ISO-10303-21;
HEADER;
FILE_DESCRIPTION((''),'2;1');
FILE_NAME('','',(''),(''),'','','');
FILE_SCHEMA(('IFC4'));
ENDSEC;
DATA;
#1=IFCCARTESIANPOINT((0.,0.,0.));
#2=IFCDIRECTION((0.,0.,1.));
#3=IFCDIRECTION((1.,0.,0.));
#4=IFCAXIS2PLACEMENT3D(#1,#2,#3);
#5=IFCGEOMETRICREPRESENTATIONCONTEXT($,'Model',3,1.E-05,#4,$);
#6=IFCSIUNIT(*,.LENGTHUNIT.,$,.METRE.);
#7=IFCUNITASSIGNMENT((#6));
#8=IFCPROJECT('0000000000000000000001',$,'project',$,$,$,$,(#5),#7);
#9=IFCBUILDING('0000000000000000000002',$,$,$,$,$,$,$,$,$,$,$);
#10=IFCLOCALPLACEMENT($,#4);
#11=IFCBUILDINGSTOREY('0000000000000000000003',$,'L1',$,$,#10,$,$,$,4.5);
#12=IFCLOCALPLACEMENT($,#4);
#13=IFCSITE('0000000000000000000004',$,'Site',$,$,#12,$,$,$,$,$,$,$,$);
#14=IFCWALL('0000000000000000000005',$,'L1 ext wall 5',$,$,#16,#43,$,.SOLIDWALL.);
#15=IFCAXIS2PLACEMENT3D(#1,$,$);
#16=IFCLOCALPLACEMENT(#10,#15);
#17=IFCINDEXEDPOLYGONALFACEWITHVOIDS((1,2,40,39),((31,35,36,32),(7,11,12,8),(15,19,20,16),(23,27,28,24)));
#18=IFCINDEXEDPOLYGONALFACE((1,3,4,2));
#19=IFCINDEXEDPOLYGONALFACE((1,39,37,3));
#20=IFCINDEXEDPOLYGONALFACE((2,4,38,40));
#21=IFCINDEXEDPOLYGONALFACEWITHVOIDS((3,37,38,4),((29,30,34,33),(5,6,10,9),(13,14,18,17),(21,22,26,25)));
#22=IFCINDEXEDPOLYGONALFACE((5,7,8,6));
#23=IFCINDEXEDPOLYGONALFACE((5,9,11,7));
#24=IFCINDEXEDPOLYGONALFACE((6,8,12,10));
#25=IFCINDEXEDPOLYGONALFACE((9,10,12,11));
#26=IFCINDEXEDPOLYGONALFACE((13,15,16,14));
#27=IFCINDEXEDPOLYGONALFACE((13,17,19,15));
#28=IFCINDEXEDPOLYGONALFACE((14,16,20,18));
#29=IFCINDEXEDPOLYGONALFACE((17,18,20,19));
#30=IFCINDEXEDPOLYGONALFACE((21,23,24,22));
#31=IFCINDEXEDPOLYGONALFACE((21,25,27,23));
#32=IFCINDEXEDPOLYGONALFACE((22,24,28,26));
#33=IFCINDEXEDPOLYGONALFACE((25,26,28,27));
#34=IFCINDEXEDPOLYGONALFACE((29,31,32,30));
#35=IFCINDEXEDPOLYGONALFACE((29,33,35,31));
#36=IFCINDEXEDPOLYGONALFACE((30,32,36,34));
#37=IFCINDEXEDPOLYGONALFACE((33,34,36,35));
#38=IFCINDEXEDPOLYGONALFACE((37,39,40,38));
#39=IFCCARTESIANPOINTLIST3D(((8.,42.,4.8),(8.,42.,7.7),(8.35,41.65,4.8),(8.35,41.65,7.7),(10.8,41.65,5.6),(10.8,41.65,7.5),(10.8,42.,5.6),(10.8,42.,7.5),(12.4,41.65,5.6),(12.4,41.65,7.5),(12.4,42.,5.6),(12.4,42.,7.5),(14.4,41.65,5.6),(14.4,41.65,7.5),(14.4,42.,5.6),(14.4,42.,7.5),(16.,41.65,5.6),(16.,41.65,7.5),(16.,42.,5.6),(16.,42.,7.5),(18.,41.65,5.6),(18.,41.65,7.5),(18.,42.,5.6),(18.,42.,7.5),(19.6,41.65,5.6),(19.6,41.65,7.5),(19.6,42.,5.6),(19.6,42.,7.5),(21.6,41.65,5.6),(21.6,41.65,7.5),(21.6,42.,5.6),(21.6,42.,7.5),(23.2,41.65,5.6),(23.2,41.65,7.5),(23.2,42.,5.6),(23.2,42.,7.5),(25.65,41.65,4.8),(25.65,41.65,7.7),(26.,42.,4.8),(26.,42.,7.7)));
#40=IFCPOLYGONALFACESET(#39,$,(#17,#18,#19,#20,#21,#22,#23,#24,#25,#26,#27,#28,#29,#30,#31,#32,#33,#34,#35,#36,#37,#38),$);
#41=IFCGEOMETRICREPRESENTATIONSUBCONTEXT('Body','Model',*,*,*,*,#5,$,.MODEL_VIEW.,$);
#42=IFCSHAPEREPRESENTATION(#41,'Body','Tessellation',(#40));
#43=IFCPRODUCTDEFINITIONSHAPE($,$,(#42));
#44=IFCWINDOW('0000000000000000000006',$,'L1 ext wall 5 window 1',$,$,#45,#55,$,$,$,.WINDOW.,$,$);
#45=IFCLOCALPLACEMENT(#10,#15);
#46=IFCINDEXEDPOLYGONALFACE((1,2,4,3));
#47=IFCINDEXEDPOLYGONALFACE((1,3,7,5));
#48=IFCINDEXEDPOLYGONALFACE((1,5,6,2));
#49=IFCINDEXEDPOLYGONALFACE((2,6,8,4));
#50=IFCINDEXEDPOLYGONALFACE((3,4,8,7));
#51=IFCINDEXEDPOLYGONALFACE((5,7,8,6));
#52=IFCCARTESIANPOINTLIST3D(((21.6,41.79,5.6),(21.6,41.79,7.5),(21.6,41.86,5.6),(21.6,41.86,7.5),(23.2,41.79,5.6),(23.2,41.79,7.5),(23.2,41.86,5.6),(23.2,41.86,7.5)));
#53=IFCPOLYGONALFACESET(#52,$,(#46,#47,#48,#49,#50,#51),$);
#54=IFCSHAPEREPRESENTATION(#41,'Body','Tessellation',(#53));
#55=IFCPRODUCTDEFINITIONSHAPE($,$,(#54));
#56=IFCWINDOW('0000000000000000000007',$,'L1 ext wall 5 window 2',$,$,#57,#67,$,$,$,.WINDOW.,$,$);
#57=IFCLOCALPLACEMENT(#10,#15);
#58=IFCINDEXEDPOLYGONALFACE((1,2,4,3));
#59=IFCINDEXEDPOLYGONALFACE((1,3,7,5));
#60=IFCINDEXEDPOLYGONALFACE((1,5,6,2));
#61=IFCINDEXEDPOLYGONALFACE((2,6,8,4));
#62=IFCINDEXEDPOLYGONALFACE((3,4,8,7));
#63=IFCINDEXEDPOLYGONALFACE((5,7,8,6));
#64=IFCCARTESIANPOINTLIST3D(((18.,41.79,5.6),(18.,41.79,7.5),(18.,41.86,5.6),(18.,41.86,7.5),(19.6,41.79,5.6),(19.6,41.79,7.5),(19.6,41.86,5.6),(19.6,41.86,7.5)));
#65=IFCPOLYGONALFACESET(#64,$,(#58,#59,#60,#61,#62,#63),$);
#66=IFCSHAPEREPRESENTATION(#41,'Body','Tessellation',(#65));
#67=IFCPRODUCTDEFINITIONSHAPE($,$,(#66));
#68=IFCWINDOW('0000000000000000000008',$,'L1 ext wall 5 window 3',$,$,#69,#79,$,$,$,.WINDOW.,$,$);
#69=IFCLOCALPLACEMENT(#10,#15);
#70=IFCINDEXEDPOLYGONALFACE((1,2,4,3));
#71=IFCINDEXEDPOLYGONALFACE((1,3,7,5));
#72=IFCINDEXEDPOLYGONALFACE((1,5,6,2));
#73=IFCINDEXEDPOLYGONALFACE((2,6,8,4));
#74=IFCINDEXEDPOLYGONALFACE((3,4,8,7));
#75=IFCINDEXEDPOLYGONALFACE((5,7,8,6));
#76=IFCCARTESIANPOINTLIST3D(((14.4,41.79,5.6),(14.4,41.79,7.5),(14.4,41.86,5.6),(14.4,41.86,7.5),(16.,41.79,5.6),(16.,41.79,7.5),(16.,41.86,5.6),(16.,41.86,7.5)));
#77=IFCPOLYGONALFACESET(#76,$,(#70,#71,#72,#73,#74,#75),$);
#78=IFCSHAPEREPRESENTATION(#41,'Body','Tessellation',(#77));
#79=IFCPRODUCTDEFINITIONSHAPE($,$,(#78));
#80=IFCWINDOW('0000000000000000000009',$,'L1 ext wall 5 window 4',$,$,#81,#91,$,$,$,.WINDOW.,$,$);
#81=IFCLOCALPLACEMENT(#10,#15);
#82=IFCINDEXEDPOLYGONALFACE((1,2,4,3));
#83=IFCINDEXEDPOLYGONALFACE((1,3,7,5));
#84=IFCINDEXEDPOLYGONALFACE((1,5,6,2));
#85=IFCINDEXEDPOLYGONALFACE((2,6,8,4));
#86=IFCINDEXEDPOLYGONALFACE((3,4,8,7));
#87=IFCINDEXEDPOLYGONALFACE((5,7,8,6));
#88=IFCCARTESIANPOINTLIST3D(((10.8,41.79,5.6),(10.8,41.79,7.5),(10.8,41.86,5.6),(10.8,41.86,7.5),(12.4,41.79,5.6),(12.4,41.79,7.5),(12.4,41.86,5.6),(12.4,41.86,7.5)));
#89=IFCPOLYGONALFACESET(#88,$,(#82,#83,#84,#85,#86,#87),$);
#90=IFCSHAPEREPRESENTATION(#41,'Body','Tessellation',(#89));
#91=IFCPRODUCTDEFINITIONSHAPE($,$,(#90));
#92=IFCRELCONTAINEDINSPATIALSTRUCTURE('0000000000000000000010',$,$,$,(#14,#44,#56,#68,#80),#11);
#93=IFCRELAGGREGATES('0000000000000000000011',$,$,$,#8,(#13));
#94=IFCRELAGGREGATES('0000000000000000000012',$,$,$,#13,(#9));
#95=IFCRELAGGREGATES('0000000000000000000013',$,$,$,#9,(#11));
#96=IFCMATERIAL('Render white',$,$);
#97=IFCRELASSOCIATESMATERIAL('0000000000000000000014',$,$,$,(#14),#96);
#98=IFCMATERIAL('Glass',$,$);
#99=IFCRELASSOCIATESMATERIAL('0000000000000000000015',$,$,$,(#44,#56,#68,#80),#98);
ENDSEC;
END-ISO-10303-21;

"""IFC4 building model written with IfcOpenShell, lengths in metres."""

from ifc_helpers import new_model, si_unit, frame, origin_with_axes, place, context, subcontext, project, spatial, polyline, outline, extrude, material, element, fill, save


model = new_model("IFC4")

# Units and contexts
model_context = context("Model", 3, precision=1e-05, world=origin_with_axes())
body_context = subcontext(model_context, "Body", "Model", "MODEL_VIEW")
ifc_project = project(units=[si_unit("LENGTHUNIT", "METRE")], contexts=[model_context])

# Site, building, storey
site_placement = place(None, origin_with_axes())
site = spatial("IfcSite", under=ifc_project, at=site_placement, Name="Site")
building = spatial("IfcBuilding", under=site)
storey_placement = place(None, origin_with_axes())
storey = spatial("IfcBuildingStorey", under=building, at=storey_placement, Name="L1", Elevation=4.5)

# Wall, openings, windows
ifc_material_1 = material(Name="Render white")
wall_1_placement = place(storey_placement, origin_with_axes())
wall_1 = element("IfcWall", 1, at=wall_1_placement, inside=storey, material=ifc_material_1, Name="L1 ext wall 5", PredefinedType="SOLIDWALL", context=body_context, shape_type="SweptSolid", body=[
    extrude(outline(polyline([(26.0, 42.0), (8.0, 42.0), (8.35, 41.65), (25.65, 41.65), (26.0, 42.0)])), frame((0.0, 0.0, 4.8), z_axis=(0.0, 0.0, 1.0), x_axis=(1.0, 0.0, 0.0)), (0.0, 0.0, 1.0), 2.9),
])
opening_1_placement = place(wall_1_placement, origin_with_axes())
opening_1 = element("IfcOpeningElement", 2, at=opening_1_placement, cuts=wall_1, context=body_context, shape_type="SweptSolid", body=[
    extrude(outline(polyline([(23.2, 42.05), (21.6, 42.05), (21.6, 41.6), (23.2, 41.6), (23.2, 42.05)])), frame((0.0, 0.0, 5.6), z_axis=(0.0, 0.0, 1.0), x_axis=(1.0, 0.0, 0.0)), (0.0, 0.0, 1.0), 1.9),
])
opening_2_placement = place(wall_1_placement, origin_with_axes())
opening_2 = element("IfcOpeningElement", 3, at=opening_2_placement, cuts=wall_1, context=body_context, shape_type="SweptSolid", body=[
    extrude(outline(polyline([(19.6, 42.05), (18.0, 42.05), (18.0, 41.6), (19.6, 41.6), (19.6, 42.05)])), frame((0.0, 0.0, 5.6), z_axis=(0.0, 0.0, 1.0), x_axis=(1.0, 0.0, 0.0)), (0.0, 0.0, 1.0), 1.9),
])
opening_3_placement = place(wall_1_placement, origin_with_axes())
opening_3 = element("IfcOpeningElement", 4, at=opening_3_placement, cuts=wall_1, context=body_context, shape_type="SweptSolid", body=[
    extrude(outline(polyline([(16.0, 42.05), (14.4, 42.05), (14.4, 41.6), (16.0, 41.6), (16.0, 42.05)])), frame((0.0, 0.0, 5.6), z_axis=(0.0, 0.0, 1.0), x_axis=(1.0, 0.0, 0.0)), (0.0, 0.0, 1.0), 1.9),
])
opening_4_placement = place(wall_1_placement, origin_with_axes())
opening_4 = element("IfcOpeningElement", 5, at=opening_4_placement, cuts=wall_1, context=body_context, shape_type="SweptSolid", body=[
    extrude(outline(polyline([(12.4, 42.05), (10.8, 42.05), (10.8, 41.6), (12.4, 41.6), (12.4, 42.05)])), frame((0.0, 0.0, 5.6), z_axis=(0.0, 0.0, 1.0), x_axis=(1.0, 0.0, 0.0)), (0.0, 0.0, 1.0), 1.9),
])
ifc_material_2 = material(Name="Glass")
window_1_placement = place(storey_placement, origin_with_axes())
window_1 = element("IfcWindow", 6, at=window_1_placement, inside=storey, material=ifc_material_2, Name="L1 ext wall 5 window 1", PredefinedType="WINDOW", context=body_context, shape_type="SweptSolid", body=[
    extrude(outline(polyline([(23.2, 41.86), (21.6, 41.86), (21.6, 41.79), (23.2, 41.79), (23.2, 41.86)])), frame((0.0, 0.0, 5.6), z_axis=(0.0, 0.0, 1.0), x_axis=(1.0, 0.0, 0.0)), (0.0, 0.0, 1.0), 1.9),
])
fill(opening_1, window_1)
window_2_placement = place(storey_placement, origin_with_axes())
window_2 = element("IfcWindow", 7, at=window_2_placement, inside=storey, material=ifc_material_2, Name="L1 ext wall 5 window 2", PredefinedType="WINDOW", context=body_context, shape_type="SweptSolid", body=[
    extrude(outline(polyline([(19.6, 41.86), (18.0, 41.86), (18.0, 41.79), (19.6, 41.79), (19.6, 41.86)])), frame((0.0, 0.0, 5.6), z_axis=(0.0, 0.0, 1.0), x_axis=(1.0, 0.0, 0.0)), (0.0, 0.0, 1.0), 1.9),
])
fill(opening_2, window_2)
window_3_placement = place(storey_placement, origin_with_axes())
window_3 = element("IfcWindow", 8, at=window_3_placement, inside=storey, material=ifc_material_2, Name="L1 ext wall 5 window 3", PredefinedType="WINDOW", context=body_context, shape_type="SweptSolid", body=[
    extrude(outline(polyline([(16.0, 41.86), (14.4, 41.86), (14.4, 41.79), (16.0, 41.79), (16.0, 41.86)])), frame((0.0, 0.0, 5.6), z_axis=(0.0, 0.0, 1.0), x_axis=(1.0, 0.0, 0.0)), (0.0, 0.0, 1.0), 1.9),
])
fill(opening_3, window_3)
window_4_placement = place(storey_placement, origin_with_axes())
window_4 = element("IfcWindow", 9, at=window_4_placement, inside=storey, material=ifc_material_2, Name="L1 ext wall 5 window 4", PredefinedType="WINDOW", context=body_context, shape_type="SweptSolid", body=[
    extrude(outline(polyline([(12.4, 41.86), (10.8, 41.86), (10.8, 41.79), (12.4, 41.79), (12.4, 41.86)])), frame((0.0, 0.0, 5.6), z_axis=(0.0, 0.0, 1.0), x_axis=(1.0, 0.0, 0.0)), (0.0, 0.0, 1.0), 1.9),
])
fill(opening_4, window_4)

save(model, "model.ifc")
